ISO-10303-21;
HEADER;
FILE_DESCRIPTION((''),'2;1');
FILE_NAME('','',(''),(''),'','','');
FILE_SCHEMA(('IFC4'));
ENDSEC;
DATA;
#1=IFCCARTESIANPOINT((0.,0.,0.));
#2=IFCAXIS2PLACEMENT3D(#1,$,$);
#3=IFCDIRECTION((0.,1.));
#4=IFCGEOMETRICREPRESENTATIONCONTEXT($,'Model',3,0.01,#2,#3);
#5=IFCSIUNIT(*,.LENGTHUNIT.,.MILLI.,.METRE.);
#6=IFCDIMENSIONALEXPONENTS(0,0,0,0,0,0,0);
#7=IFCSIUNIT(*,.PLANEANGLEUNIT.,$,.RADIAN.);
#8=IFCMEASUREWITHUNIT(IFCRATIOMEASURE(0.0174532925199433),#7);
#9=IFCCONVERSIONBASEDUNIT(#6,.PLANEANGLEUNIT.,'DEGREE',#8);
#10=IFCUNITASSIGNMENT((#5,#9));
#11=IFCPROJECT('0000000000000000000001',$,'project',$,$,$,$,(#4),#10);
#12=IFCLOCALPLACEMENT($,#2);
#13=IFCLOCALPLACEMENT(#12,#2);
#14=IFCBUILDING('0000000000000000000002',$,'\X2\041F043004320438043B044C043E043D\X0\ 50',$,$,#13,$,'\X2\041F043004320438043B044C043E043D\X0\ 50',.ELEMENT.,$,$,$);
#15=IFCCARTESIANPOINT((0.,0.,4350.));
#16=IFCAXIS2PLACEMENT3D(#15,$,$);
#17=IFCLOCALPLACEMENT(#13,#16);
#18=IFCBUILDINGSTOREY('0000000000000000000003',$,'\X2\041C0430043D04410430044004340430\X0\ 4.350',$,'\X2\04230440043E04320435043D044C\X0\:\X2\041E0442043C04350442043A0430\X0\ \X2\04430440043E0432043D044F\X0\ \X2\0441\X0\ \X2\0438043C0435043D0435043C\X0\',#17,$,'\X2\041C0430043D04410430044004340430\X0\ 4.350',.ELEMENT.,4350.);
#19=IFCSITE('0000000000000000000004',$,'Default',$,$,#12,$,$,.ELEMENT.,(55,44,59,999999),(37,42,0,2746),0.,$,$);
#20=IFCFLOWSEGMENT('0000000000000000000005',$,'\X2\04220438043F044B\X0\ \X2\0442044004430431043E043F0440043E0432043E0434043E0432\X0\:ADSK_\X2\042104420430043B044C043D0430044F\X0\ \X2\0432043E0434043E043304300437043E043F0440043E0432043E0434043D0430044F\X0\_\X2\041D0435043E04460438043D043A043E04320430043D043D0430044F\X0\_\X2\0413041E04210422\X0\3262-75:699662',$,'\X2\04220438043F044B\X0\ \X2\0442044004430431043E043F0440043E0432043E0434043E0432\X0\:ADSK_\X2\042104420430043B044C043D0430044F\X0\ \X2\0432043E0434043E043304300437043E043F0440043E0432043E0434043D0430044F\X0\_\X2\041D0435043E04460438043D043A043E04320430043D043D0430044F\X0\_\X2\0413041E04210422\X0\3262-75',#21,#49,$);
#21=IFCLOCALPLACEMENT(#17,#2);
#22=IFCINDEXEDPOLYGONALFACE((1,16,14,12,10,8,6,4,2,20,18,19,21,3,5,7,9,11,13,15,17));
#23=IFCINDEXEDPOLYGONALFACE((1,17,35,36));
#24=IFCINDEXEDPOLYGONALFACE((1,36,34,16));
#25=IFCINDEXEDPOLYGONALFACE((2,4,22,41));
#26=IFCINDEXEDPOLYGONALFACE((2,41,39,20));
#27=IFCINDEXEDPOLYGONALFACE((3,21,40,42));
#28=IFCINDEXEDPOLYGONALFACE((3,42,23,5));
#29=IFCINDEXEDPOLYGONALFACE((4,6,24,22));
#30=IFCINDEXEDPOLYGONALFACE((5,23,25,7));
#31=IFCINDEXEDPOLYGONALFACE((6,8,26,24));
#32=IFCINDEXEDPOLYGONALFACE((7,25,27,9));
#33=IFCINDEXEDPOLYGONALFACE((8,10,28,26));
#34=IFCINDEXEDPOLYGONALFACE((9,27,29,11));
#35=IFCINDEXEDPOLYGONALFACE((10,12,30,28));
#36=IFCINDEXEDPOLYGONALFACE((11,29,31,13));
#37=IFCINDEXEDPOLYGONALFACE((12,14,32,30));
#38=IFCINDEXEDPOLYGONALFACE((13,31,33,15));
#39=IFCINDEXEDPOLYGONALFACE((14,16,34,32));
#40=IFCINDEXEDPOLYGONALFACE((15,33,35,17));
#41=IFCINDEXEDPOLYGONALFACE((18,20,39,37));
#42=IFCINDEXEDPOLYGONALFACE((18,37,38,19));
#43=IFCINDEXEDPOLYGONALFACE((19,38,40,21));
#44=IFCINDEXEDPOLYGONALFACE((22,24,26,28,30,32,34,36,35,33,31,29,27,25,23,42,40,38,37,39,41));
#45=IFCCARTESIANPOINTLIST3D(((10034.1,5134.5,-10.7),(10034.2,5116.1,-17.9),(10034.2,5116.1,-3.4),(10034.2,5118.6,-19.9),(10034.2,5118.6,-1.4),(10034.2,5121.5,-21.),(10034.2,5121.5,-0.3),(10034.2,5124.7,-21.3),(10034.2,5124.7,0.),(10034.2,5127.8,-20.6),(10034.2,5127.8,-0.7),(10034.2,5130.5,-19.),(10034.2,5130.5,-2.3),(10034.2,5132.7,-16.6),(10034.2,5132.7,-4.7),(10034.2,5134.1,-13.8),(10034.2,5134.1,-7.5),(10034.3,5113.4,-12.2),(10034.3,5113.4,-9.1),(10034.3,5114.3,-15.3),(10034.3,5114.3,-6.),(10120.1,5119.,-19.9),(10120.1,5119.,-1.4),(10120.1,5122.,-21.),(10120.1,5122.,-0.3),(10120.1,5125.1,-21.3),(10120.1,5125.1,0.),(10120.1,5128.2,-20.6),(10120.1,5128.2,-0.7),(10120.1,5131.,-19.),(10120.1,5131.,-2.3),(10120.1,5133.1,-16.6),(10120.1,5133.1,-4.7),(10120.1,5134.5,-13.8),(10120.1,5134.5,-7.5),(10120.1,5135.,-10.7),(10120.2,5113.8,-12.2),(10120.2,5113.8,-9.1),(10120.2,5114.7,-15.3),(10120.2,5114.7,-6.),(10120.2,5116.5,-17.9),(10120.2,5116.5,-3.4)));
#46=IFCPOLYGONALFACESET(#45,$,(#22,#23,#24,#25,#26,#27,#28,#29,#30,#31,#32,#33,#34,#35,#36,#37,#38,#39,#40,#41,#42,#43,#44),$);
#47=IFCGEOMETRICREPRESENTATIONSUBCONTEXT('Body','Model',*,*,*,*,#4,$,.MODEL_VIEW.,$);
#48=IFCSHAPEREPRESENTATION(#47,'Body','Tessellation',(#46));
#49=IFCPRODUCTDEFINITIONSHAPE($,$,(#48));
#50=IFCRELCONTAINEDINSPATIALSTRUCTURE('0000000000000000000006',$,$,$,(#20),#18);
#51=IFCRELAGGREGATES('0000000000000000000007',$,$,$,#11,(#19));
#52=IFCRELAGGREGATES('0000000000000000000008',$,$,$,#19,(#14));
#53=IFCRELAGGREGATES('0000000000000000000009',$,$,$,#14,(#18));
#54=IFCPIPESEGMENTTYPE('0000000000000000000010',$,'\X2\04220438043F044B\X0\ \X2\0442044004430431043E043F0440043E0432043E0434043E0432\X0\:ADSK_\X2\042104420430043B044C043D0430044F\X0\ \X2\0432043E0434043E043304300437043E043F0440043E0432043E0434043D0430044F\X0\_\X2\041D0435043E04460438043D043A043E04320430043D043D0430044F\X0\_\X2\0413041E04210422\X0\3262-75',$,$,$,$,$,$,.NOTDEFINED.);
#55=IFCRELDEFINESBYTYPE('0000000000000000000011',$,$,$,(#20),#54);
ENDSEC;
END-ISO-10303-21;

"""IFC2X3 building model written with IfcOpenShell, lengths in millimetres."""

from ifc_helpers import new_model, entity, si_unit, converted_unit, direction, frame, origin, origin_2d_with_axis, place, context, subcontext, project, spatial, circle, extrude, type_object, element, save


model = new_model("IFC2X3")

# Units and contexts
model_context = context("Model", 3, precision=0.01, world=origin(), true_north=direction((0.0, 1.0)))
body_context = subcontext(model_context, "Body", "Model", "MODEL_VIEW")
ifc_project = project(units=[si_unit("LENGTHUNIT", "METRE", prefix="MILLI"), converted_unit("PLANEANGLEUNIT", "DEGREE", entity("IfcRatioMeasure", 0.0174532925199433), si_unit("PLANEANGLEUNIT", "RADIAN"), dimensions=[0, 0, 0, 0, 0, 0, 0])], contexts=[model_context])

# Site, building, storey
site_placement = place(None, origin())
site = spatial("IfcSite", under=ifc_project, at=site_placement, Name="Default", CompositionType="ELEMENT", RefLatitude=(55, 44, 59, 999999), RefLongitude=(37, 42, 0, 2746), RefElevation=0.0)
building_placement = place(site_placement, origin())
building = spatial("IfcBuilding", under=site, at=building_placement, Name="Павильон 50", LongName="Павильон 50", CompositionType="ELEMENT")
storey_placement = place(building_placement, frame((0.0, 0.0, 4350.0)))
storey = spatial("IfcBuildingStorey", under=building, at=storey_placement, Name="Мансарда 4.350", ObjectType="Уровень:Отметка уровня с именем", LongName="Мансарда 4.350", CompositionType="ELEMENT", Elevation=4350.0)

# Flow segment
pipe_segment_type = type_object("IfcPipeSegmentType", Name="Типы трубопроводов:ADSK_Стальная водогазопроводная_Неоцинкованная_ГОСТ3262-75", PredefinedType="NOTDEFINED")
flow_segment_1_placement = place(storey_placement, frame((10034.1, 5111.6, -22.9)))
element("IfcFlowSegment", 1, at=flow_segment_1_placement, inside=storey, type_object=pipe_segment_type, Name="Типы трубопроводов:ADSK_Стальная водогазопроводная_Неоцинкованная_ГОСТ3262-75:699662", ObjectType="Типы трубопроводов:ADSK_Стальная водогазопроводная_Неоцинкованная_ГОСТ3262-75", context=body_context, shape_type="SweptSolid", body=[
    extrude(circle(Radius=10.7, at=origin_2d_with_axis()), frame((0.1, 12.2, 12.2), z_axis=(0.999987, 0.005103, 0.0), x_axis=(-0.005103, 0.999987, 0.0)), (0.0, 0.0, 1.0), 85.9),
])

save(model, "model.ifc")
